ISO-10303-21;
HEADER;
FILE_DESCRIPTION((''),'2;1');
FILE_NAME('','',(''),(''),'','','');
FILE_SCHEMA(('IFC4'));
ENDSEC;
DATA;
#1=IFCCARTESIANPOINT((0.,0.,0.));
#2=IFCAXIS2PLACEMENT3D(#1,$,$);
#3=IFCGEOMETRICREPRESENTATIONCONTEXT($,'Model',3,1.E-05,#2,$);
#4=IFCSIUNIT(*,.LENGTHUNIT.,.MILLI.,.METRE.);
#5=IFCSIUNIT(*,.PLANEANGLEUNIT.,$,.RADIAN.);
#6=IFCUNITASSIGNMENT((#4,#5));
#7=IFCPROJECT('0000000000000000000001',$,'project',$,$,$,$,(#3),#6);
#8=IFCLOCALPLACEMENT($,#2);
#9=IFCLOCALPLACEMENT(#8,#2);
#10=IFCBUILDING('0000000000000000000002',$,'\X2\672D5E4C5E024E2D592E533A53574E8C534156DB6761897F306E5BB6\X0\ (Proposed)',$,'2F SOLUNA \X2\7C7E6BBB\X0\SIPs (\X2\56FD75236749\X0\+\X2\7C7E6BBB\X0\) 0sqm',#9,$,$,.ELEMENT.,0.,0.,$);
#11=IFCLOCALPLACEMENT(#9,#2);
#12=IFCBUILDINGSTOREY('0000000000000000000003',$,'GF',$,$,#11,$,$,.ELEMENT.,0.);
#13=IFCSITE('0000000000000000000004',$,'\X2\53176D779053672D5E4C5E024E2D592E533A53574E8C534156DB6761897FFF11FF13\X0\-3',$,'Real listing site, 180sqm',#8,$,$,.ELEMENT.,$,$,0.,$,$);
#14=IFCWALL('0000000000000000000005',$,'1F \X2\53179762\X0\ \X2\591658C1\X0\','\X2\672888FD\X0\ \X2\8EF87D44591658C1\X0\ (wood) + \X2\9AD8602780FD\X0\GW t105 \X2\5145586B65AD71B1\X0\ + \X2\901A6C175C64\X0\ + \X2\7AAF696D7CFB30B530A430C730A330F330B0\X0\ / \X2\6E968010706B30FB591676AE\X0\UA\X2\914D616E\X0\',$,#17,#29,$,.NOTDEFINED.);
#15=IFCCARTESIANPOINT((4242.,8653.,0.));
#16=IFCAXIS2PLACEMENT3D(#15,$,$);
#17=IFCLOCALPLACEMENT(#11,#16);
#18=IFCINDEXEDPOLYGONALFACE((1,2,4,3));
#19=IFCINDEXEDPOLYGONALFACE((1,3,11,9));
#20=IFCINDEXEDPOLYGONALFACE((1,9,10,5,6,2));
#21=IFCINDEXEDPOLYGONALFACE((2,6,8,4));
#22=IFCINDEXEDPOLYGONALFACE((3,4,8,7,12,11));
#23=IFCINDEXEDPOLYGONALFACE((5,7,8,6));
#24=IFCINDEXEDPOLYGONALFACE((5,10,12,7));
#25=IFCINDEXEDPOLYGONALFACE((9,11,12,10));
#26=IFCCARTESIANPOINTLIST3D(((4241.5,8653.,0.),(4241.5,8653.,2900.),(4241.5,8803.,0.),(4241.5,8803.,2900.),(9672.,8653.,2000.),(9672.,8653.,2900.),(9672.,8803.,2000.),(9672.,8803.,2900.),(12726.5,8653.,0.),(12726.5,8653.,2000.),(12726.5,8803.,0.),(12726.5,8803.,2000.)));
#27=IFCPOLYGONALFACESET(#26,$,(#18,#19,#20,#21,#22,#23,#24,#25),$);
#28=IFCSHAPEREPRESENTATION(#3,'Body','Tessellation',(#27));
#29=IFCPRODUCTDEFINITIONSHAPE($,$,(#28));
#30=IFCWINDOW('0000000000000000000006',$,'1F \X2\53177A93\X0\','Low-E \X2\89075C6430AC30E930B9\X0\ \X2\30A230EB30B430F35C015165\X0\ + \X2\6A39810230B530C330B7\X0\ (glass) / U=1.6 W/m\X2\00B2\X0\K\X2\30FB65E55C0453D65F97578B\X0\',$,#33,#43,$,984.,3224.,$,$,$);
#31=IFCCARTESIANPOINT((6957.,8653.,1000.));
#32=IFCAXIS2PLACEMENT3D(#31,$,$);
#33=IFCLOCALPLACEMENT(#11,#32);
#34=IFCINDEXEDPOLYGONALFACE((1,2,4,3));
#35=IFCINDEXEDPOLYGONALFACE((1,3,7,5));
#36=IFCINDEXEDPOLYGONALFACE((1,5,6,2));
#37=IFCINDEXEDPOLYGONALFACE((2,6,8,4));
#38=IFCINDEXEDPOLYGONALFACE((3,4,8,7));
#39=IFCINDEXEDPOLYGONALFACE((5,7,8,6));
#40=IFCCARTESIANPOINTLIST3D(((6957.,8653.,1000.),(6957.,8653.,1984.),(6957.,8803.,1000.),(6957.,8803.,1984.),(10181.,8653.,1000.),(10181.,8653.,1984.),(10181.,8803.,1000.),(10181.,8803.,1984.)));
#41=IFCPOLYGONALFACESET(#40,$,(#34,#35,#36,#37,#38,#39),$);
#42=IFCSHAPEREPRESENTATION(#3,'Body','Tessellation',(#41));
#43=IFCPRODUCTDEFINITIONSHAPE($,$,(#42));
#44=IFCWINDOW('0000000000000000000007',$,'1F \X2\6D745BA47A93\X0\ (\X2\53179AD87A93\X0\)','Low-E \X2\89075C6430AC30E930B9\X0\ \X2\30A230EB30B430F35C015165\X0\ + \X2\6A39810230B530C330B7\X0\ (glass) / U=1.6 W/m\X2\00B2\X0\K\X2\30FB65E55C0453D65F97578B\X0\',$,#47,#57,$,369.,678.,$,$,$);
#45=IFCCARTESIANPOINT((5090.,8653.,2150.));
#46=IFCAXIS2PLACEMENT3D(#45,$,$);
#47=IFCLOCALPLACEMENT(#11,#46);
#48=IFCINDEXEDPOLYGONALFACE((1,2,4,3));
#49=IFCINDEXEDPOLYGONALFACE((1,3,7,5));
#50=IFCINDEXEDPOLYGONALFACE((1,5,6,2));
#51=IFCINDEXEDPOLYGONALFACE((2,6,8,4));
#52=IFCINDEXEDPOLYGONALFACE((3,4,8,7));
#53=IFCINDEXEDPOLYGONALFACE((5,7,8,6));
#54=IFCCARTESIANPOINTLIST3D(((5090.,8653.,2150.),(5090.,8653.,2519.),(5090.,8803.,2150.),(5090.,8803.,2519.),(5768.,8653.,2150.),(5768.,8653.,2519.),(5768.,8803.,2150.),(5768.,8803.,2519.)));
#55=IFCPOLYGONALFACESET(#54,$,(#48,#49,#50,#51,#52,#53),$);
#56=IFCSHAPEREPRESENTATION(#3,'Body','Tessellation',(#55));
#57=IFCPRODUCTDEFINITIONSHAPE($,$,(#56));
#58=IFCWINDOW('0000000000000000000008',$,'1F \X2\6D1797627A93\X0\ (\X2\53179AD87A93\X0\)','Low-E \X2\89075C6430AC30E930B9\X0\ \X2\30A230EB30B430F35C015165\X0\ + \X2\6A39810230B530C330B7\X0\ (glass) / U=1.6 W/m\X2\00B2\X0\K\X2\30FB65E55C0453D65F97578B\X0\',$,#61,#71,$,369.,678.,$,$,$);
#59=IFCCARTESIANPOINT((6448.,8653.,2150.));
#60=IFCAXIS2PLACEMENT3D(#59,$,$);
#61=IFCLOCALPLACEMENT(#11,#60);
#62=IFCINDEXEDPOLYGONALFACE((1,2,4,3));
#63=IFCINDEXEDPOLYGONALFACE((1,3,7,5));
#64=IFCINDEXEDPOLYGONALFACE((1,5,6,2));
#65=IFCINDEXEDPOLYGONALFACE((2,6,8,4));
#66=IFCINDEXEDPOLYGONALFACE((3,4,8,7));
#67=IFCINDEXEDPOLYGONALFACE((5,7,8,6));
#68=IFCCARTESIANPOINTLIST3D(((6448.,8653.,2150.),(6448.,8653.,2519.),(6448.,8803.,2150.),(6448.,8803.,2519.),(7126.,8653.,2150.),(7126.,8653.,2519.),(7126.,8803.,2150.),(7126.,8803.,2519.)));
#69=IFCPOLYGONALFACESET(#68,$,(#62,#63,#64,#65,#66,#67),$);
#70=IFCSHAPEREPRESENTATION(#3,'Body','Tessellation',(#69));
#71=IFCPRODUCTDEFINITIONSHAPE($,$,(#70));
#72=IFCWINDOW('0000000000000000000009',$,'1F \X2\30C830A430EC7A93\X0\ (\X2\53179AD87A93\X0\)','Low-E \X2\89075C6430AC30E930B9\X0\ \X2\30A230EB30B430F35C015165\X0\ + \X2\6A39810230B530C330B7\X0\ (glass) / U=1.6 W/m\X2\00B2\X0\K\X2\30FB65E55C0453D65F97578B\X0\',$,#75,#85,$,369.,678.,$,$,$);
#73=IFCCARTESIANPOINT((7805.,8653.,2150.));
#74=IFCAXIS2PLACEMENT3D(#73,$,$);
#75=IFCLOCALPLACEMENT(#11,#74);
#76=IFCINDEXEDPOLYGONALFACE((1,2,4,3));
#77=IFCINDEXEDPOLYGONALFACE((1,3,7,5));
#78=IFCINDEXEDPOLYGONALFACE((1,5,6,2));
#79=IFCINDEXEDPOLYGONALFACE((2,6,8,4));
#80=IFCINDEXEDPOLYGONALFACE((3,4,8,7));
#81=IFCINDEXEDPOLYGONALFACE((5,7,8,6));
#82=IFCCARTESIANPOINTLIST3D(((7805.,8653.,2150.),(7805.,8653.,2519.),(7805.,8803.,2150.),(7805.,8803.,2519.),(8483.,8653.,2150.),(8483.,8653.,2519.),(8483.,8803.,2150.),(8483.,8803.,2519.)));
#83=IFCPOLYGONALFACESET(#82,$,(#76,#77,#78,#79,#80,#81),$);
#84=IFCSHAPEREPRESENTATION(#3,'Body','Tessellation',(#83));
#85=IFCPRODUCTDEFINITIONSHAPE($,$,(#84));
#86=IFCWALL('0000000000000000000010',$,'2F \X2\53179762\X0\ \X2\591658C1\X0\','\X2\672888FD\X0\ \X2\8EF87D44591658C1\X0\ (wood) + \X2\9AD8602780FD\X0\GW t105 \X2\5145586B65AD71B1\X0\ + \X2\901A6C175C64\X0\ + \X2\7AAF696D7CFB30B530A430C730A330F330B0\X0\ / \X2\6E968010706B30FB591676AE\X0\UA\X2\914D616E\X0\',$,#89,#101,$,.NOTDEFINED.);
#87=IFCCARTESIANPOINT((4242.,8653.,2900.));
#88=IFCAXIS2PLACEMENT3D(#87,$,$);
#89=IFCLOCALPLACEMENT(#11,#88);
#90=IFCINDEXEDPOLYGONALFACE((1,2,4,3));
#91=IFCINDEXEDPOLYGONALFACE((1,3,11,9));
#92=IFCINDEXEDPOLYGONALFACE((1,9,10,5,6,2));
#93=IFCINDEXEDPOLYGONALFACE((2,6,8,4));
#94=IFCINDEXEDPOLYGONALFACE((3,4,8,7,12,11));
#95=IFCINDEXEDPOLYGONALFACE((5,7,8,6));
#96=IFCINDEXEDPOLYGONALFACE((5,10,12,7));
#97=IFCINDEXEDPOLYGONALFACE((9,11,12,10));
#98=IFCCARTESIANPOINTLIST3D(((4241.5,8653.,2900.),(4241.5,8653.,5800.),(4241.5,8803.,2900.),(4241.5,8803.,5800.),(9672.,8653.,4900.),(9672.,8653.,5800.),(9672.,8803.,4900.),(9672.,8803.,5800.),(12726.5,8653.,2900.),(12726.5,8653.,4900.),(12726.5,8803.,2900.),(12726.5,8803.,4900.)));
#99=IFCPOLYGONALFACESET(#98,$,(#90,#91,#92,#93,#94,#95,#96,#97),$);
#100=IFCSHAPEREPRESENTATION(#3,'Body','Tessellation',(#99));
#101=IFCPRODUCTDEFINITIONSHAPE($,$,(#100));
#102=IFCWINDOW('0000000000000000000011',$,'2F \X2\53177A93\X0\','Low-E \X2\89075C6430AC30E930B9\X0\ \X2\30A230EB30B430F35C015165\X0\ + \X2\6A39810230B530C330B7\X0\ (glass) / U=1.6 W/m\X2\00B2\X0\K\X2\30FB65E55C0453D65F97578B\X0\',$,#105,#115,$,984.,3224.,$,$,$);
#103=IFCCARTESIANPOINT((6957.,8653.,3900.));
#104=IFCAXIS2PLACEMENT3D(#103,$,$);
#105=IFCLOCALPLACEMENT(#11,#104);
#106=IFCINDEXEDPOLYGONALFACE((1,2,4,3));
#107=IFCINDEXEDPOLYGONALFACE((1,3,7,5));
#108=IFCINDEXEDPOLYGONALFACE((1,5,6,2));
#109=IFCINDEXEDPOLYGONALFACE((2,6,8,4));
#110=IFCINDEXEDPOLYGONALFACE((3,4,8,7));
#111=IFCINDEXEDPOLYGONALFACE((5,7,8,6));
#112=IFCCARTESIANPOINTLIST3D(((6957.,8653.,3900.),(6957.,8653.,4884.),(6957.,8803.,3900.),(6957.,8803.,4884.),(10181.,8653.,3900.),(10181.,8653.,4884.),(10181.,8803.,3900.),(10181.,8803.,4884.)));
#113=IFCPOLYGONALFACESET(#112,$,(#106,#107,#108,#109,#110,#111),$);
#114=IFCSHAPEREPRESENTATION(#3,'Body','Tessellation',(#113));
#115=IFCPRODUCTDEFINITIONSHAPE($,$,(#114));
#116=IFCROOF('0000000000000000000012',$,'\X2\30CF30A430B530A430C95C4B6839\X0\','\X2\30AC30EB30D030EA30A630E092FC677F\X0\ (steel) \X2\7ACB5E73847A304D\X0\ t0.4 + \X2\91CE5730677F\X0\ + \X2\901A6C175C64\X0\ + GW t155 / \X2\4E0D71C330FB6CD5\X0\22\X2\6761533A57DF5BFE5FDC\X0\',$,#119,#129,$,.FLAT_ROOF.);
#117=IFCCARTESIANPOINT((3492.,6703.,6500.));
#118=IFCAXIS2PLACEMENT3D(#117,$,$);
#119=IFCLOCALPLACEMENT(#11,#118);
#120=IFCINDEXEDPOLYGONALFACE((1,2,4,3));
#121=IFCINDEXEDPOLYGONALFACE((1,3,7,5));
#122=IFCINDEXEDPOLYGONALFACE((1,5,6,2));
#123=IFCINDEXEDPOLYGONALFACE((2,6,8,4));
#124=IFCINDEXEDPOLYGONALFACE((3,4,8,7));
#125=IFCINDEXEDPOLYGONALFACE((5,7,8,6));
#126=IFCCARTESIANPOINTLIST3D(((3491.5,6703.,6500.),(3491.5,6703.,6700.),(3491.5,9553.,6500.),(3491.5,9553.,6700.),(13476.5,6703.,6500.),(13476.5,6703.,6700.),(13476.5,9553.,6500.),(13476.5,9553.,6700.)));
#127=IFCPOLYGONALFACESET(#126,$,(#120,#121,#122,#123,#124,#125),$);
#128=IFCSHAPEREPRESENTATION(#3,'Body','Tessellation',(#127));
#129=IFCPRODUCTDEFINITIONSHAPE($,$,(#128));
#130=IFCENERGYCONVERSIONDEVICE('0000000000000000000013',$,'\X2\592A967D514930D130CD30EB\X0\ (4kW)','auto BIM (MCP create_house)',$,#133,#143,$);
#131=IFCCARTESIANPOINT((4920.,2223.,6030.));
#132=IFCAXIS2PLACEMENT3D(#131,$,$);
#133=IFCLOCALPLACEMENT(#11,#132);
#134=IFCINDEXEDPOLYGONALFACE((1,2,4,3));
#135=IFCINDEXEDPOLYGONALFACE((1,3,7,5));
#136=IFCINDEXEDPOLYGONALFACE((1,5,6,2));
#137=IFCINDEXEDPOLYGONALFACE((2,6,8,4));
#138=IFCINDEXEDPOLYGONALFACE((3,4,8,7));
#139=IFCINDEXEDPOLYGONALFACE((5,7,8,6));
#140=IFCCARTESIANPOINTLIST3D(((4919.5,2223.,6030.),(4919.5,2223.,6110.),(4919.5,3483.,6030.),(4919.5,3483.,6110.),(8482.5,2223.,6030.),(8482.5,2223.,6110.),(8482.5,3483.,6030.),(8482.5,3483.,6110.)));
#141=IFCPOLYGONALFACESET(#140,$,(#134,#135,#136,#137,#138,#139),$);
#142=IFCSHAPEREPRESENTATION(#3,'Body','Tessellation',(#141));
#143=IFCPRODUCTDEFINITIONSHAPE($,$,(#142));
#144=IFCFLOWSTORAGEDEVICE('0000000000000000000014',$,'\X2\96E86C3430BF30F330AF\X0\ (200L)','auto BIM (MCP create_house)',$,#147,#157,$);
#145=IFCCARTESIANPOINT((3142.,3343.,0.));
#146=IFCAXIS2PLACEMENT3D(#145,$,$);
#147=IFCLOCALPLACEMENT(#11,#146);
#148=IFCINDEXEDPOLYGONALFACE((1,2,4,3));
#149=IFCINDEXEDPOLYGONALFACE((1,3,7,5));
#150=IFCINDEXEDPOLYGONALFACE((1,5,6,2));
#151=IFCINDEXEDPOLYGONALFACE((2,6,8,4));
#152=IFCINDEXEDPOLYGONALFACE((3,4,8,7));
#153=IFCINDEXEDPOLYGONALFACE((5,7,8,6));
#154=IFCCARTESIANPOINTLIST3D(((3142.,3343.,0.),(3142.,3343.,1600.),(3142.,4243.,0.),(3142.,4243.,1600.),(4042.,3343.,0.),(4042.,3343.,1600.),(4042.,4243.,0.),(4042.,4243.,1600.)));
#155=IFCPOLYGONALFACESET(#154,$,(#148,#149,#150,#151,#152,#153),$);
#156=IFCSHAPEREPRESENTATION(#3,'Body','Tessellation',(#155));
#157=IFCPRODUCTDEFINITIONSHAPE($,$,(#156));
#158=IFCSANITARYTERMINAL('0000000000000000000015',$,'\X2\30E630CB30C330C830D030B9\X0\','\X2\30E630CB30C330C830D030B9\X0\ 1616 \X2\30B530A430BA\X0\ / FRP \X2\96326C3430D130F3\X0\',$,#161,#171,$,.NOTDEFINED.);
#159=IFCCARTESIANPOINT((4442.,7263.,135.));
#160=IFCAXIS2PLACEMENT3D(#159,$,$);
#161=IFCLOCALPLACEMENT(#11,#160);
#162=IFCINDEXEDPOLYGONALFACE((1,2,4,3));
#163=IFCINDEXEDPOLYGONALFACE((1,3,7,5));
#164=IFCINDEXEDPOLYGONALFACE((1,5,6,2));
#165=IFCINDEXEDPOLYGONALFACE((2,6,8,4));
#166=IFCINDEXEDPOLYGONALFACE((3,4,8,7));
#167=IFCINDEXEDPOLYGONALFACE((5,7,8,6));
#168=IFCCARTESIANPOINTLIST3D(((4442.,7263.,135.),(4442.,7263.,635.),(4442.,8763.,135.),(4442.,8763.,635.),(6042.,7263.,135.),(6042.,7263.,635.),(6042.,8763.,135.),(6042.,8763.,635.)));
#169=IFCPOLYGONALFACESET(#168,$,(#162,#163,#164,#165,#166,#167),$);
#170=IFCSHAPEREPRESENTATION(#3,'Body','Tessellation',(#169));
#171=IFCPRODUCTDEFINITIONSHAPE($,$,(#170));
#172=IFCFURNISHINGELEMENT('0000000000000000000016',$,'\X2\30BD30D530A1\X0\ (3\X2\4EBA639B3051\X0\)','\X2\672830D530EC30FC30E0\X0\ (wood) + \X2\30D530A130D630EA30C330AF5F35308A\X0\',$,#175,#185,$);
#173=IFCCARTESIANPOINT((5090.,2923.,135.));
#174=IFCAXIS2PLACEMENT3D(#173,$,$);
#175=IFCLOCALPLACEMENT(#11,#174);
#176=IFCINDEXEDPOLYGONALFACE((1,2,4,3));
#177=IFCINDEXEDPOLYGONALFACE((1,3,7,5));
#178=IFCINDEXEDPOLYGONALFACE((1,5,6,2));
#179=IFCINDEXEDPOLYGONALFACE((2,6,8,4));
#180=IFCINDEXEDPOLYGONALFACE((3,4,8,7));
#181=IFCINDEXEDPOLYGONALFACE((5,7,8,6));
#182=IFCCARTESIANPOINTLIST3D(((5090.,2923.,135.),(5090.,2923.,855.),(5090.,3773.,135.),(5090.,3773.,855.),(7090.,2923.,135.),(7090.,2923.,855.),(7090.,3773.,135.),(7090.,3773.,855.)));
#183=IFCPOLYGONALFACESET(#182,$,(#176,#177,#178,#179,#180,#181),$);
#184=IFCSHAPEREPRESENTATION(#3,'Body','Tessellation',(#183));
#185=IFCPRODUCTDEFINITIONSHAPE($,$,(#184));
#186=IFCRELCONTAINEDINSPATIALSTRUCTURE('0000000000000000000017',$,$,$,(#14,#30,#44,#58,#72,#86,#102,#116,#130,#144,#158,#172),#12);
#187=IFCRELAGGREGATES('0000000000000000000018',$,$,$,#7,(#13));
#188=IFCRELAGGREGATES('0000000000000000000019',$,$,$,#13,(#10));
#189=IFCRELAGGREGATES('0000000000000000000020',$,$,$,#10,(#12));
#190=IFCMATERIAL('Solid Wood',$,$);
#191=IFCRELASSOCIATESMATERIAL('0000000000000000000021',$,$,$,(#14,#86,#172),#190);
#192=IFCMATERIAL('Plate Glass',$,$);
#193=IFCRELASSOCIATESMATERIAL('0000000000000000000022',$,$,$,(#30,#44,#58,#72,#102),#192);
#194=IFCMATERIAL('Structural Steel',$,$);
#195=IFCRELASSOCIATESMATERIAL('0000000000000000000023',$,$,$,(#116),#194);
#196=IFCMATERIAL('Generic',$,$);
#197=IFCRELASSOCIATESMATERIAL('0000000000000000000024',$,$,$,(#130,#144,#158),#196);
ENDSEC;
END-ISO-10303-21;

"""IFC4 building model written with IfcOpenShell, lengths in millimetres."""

from ifc_helpers import new_model, si_unit, frame, frame_2d, origin, place, context, project, spatial, rectangle, extrude, material, element, fill, save


model = new_model("IFC4")

# Units and contexts
model_context = context("Model", 3, precision=1e-05, world=origin())
ifc_project = project(units=[si_unit("LENGTHUNIT", "METRE", prefix="MILLI"), si_unit("PLANEANGLEUNIT", "RADIAN")], contexts=[model_context])

# Site, building, storey
site_placement = place(None, origin())
site = spatial("IfcSite", under=ifc_project, at=site_placement, Name="北海道札幌市中央区南二十四条西１３-3", ObjectType="Real listing site, 180sqm", CompositionType="ELEMENT", RefElevation=0.0)
building_placement = place(site_placement, origin())
building = spatial("IfcBuilding", under=site, at=building_placement, Name="札幌市中央区南二十四条西の家 (Proposed)", ObjectType="2F SOLUNA 籾殻SIPs (国産杉+籾殻) 0sqm", CompositionType="ELEMENT", ElevationOfRefHeight=0.0, ElevationOfTerrain=0.0)
storey_placement = place(building_placement, origin())
storey = spatial("IfcBuildingStorey", under=building, at=storey_placement, Name="GF", CompositionType="ELEMENT", Elevation=0.0)

# Wall, openings, windows
ifc_material_1 = material(Name="Solid Wood")
wall_1_placement = place(storey_placement, frame((4242.0, 8653.0, 0.0)))
wall_1 = element("IfcWall", 1, at=wall_1_placement, inside=storey, material=ifc_material_1, Name="1F 北面 外壁", Description="木製 軸組外壁 (wood) + 高性能GW t105 充填断熱 + 通気層 + 窯業系サイディング / 準耐火・外皮UA配慮", PredefinedType="NOTDEFINED", context=model_context, shape_type="SweptSolid", body=[
    extrude(rectangle(XDim=8485.0, YDim=150.0, at=frame_2d((4242.0, 75.0))), frame((4242.0, 8653.0, 0.0)), (0.0, 0.0, 1.0), 2900.0),
])
opening_1_placement = place(storey_placement, frame((6957.0, 8653.0, 1000.0)))
opening_1 = element("IfcOpeningElement", 2, at=opening_1_placement, cuts=wall_1, PredefinedType="NOTDEFINED", context=model_context, shape_type="SweptSolid", body=[
    extrude(rectangle(XDim=3224.0, YDim=150.0, at=frame_2d((1612.0, 75.0))), frame((6957.0, 8653.0, 1000.0)), (0.0, 0.0, 1.0), 984.0),
])
opening_2_placement = place(storey_placement, frame((5090.0, 8653.0, 2150.0)))
opening_2 = element("IfcOpeningElement", 3, at=opening_2_placement, cuts=wall_1, PredefinedType="NOTDEFINED", context=model_context, shape_type="SweptSolid", body=[
    extrude(rectangle(XDim=678.0, YDim=150.0, at=frame_2d((339.0, 75.0))), frame((5090.0, 8653.0, 2150.0)), (0.0, 0.0, 1.0), 369.0),
])
opening_3_placement = place(storey_placement, frame((6448.0, 8653.0, 2150.0)))
opening_3 = element("IfcOpeningElement", 4, at=opening_3_placement, cuts=wall_1, PredefinedType="NOTDEFINED", context=model_context, shape_type="SweptSolid", body=[
    extrude(rectangle(XDim=678.0, YDim=150.0, at=frame_2d((339.0, 75.0))), frame((6448.0, 8653.0, 2150.0)), (0.0, 0.0, 1.0), 369.0),
])
opening_4_placement = place(storey_placement, frame((7805.0, 8653.0, 2150.0)))
opening_4 = element("IfcOpeningElement", 5, at=opening_4_placement, cuts=wall_1, PredefinedType="NOTDEFINED", context=model_context, shape_type="SweptSolid", body=[
    extrude(rectangle(XDim=678.0, YDim=150.0, at=frame_2d((339.0, 75.0))), frame((7805.0, 8653.0, 2150.0)), (0.0, 0.0, 1.0), 369.0),
])
ifc_material_2 = material(Name="Plate Glass")
window_1_placement = place(storey_placement, frame((6957.0, 8653.0, 1000.0)))
window_1 = element("IfcWindow", 6, at=window_1_placement, inside=storey, material=ifc_material_2, Name="1F 北窓", Description="Low-E 複層ガラス アルゴン封入 + 樹脂サッシ (glass) / U=1.6 W/m²K・日射取得型", OverallHeight=984.0, OverallWidth=3224.0, context=model_context, shape_type="SweptSolid", body=[
    extrude(rectangle(XDim=3224.0, YDim=150.0, at=frame_2d((1612.0, 75.0))), frame((6957.0, 8653.0, 1000.0)), (0.0, 0.0, 1.0), 984.0),
])
fill(opening_1, window_1)
window_2_placement = place(storey_placement, frame((5090.0, 8653.0, 2150.0)))
window_2 = element("IfcWindow", 7, at=window_2_placement, inside=storey, material=ifc_material_2, Name="1F 浴室窓 (北高窓)", Description="Low-E 複層ガラス アルゴン封入 + 樹脂サッシ (glass) / U=1.6 W/m²K・日射取得型", OverallHeight=369.0, OverallWidth=678.0, context=model_context, shape_type="SweptSolid", body=[
    extrude(rectangle(XDim=678.0, YDim=150.0, at=frame_2d((339.0, 75.0))), frame((5090.0, 8653.0, 2150.0)), (0.0, 0.0, 1.0), 369.0),
])
fill(opening_2, window_2)
window_3_placement = place(storey_placement, frame((6448.0, 8653.0, 2150.0)))
window_3 = element("IfcWindow", 8, at=window_3_placement, inside=storey, material=ifc_material_2, Name="1F 洗面窓 (北高窓)", Description="Low-E 複層ガラス アルゴン封入 + 樹脂サッシ (glass) / U=1.6 W/m²K・日射取得型", OverallHeight=369.0, OverallWidth=678.0, context=model_context, shape_type="SweptSolid", body=[
    extrude(rectangle(XDim=678.0, YDim=150.0, at=frame_2d((339.0, 75.0))), frame((6448.0, 8653.0, 2150.0)), (0.0, 0.0, 1.0), 369.0),
])
fill(opening_3, window_3)
window_4_placement = place(storey_placement, frame((7805.0, 8653.0, 2150.0)))
window_4 = element("IfcWindow", 9, at=window_4_placement, inside=storey, material=ifc_material_2, Name="1F トイレ窓 (北高窓)", Description="Low-E 複層ガラス アルゴン封入 + 樹脂サッシ (glass) / U=1.6 W/m²K・日射取得型", OverallHeight=369.0, OverallWidth=678.0, context=model_context, shape_type="SweptSolid", body=[
    extrude(rectangle(XDim=678.0, YDim=150.0, at=frame_2d((339.0, 75.0))), frame((7805.0, 8653.0, 2150.0)), (0.0, 0.0, 1.0), 369.0),
])
fill(opening_4, window_4)

# Wall, opening, window
wall_2_placement = place(storey_placement, frame((4242.0, 8653.0, 2900.0)))
wall_2 = element("IfcWall", 10, at=wall_2_placement, inside=storey, material=ifc_material_1, Name="2F 北面 外壁", Description="木製 軸組外壁 (wood) + 高性能GW t105 充填断熱 + 通気層 + 窯業系サイディング / 準耐火・外皮UA配慮", PredefinedType="NOTDEFINED", context=model_context, shape_type="SweptSolid", body=[
    extrude(rectangle(XDim=8485.0, YDim=150.0, at=frame_2d((4242.0, 75.0))), frame((4242.0, 8653.0, 2900.0)), (0.0, 0.0, 1.0), 2900.0),
])
opening_5_placement = place(storey_placement, frame((6957.0, 8653.0, 3900.0)))
opening_5 = element("IfcOpeningElement", 11, at=opening_5_placement, cuts=wall_2, PredefinedType="NOTDEFINED", context=model_context, shape_type="SweptSolid", body=[
    extrude(rectangle(XDim=3224.0, YDim=150.0, at=frame_2d((1612.0, 75.0))), frame((6957.0, 8653.0, 3900.0)), (0.0, 0.0, 1.0), 984.0),
])
window_5_placement = place(storey_placement, frame((6957.0, 8653.0, 3900.0)))
window_5 = element("IfcWindow", 12, at=window_5_placement, inside=storey, material=ifc_material_2, Name="2F 北窓", Description="Low-E 複層ガラス アルゴン封入 + 樹脂サッシ (glass) / U=1.6 W/m²K・日射取得型", OverallHeight=984.0, OverallWidth=3224.0, context=model_context, shape_type="SweptSolid", body=[
    extrude(rectangle(XDim=3224.0, YDim=150.0, at=frame_2d((1612.0, 75.0))), frame((6957.0, 8653.0, 3900.0)), (0.0, 0.0, 1.0), 984.0),
])
fill(opening_5, window_5)

# Roof
ifc_material_3 = material(Name="Structural Steel")
roof_placement = place(storey_placement, frame((3492.0, 6703.0, 6500.0)))
element("IfcRoof", 13, at=roof_placement, inside=storey, material=ifc_material_3, Name="ハイサイド屋根", Description="ガルバリウム鋼板 (steel) 立平葺き t0.4 + 野地板 + 通気層 + GW t155 / 不燃・法22条区域対応", PredefinedType="FLAT_ROOF", context=model_context, shape_type="SweptSolid", body=[
    extrude(rectangle(XDim=9985.0, YDim=2850.0, at=frame_2d((4992.0, 1425.0))), frame((3492.0, 6703.0, 6500.0)), (0.0, 0.0, 1.0), 200.0),
])

# Energy conversion device
ifc_material_4 = material(Name="Generic")
energy_conversion_device_placement = place(storey_placement, frame((4920.0, 2223.0, 6030.0)))
element("IfcEnergyConversionDevice", 14, at=energy_conversion_device_placement, inside=storey, material=ifc_material_4, Name="太陽光パネル (4kW)", Description="auto BIM (MCP create_house)", context=model_context, shape_type="SweptSolid", body=[
    extrude(rectangle(XDim=3563.0, YDim=1260.0, at=frame_2d((1781.0, 630.0))), frame((4920.0, 2223.0, 6030.0)), (0.0, 0.0, 1.0), 80.0),
])

# Flow storage device
flow_storage_device_placement = place(storey_placement, frame((3142.0, 3343.0, 0.0)))
element("IfcFlowStorageDevice", 15, at=flow_storage_device_placement, inside=storey, material=ifc_material_4, Name="雨水タンク (200L)", Description="auto BIM (MCP create_house)", context=model_context, shape_type="SweptSolid", body=[
    extrude(rectangle(XDim=900.0, YDim=900.0, at=frame_2d((450.0, 450.0))), frame((3142.0, 3343.0, 0.0)), (0.0, 0.0, 1.0), 1600.0),
])

# Sanitary terminal
sanitary_terminal_placement = place(storey_placement, frame((4442.0, 7263.0, 135.0)))
element("IfcSanitaryTerminal", 16, at=sanitary_terminal_placement, inside=storey, material=ifc_material_4, Name="ユニットバス", Description="ユニットバス 1616 サイズ / FRP 防水パン", PredefinedType="NOTDEFINED", context=model_context, shape_type="SweptSolid", body=[
    extrude(rectangle(XDim=1600.0, YDim=1500.0, at=frame_2d((800.0, 750.0))), frame((4442.0, 7263.0, 135.0)), (0.0, 0.0, 1.0), 500.0),
])

# Furnishing element
furnishing_1_placement = place(storey_placement, frame((5090.0, 2923.0, 135.0)))
element("IfcFurnishingElement", 17, at=furnishing_1_placement, inside=storey, material=ifc_material_1, Name="ソファ (3人掛け)", Description="木フレーム (wood) + ファブリック張り", context=model_context, shape_type="SweptSolid", body=[
    extrude(rectangle(XDim=2000.0, YDim=850.0, at=frame_2d((1000.0, 425.0))), frame((5090.0, 2923.0, 135.0)), (0.0, 0.0, 1.0), 720.0),
])

save(model, "model.ifc")
